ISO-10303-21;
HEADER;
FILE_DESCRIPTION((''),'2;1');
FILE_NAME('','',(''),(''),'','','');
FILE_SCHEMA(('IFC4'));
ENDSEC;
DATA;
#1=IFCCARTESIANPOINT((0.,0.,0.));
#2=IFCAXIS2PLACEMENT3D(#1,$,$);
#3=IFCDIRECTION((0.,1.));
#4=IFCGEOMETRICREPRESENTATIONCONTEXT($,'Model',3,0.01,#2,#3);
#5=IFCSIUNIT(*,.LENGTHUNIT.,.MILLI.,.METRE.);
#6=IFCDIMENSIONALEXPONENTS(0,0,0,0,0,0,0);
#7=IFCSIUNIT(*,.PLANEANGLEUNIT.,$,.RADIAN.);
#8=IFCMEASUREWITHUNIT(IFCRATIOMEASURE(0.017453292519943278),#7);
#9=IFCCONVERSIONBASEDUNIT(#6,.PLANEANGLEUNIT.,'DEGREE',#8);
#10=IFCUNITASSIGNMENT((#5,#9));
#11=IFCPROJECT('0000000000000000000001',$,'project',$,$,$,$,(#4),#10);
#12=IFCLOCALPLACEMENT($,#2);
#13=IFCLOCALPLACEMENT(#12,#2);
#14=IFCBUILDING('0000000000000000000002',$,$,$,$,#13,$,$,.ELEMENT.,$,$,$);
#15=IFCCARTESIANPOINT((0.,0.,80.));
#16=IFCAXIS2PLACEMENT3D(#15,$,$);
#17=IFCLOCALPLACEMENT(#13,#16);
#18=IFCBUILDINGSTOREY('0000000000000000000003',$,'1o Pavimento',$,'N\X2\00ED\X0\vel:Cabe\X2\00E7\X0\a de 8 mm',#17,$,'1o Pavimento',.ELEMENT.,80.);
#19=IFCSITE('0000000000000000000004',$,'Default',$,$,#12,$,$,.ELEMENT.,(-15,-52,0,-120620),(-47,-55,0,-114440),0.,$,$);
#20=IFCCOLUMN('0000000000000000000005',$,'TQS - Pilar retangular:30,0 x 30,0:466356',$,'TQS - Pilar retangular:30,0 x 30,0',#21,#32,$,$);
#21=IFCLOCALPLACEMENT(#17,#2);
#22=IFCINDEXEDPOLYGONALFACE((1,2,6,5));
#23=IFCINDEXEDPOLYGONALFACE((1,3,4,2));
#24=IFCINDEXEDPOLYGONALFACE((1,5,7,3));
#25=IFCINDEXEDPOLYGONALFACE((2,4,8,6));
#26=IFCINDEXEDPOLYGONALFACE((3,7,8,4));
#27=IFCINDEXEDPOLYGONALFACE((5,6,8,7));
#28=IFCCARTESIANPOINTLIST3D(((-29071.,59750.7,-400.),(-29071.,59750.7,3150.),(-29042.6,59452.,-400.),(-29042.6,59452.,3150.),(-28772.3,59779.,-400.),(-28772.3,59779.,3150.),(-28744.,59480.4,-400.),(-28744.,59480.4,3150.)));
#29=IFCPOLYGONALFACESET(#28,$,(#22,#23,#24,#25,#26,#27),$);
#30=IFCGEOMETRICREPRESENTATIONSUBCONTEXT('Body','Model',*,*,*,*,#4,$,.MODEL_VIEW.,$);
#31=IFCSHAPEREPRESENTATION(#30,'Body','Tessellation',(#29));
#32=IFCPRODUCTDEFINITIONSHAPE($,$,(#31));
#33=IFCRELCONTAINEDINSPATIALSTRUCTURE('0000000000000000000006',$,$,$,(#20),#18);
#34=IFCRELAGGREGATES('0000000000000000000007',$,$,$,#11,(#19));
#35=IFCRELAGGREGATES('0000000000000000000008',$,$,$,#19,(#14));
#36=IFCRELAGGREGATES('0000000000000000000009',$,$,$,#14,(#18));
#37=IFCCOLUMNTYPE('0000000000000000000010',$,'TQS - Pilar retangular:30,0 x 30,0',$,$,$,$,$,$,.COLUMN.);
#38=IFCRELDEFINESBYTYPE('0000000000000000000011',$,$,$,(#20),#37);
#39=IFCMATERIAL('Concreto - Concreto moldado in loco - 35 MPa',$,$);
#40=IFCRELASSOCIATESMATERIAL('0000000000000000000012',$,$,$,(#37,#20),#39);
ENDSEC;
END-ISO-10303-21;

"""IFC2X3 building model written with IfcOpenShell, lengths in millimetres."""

from ifc_helpers import new_model, entity, si_unit, converted_unit, direction, frame, origin, origin_2d_with_axis, place, context, subcontext, project, spatial, rectangle, extrude, source, transform, mapped, material, type_object, type_shapes, element, save


model = new_model("IFC2X3")

# Units and contexts
model_context = context("Model", 3, precision=0.01, world=origin(), true_north=direction((0.0, 1.0)))
body_context = subcontext(model_context, "Body", "Model", "MODEL_VIEW")
ifc_project = project(units=[si_unit("LENGTHUNIT", "METRE", prefix="MILLI"), converted_unit("PLANEANGLEUNIT", "DEGREE", entity("IfcRatioMeasure", 0.017453292519943278), si_unit("PLANEANGLEUNIT", "RADIAN"), dimensions=[0, 0, 0, 0, 0, 0, 0])], contexts=[model_context])

# Site, building, storey
site_placement = place(None, origin())
site = spatial("IfcSite", under=ifc_project, at=site_placement, Name="Default", CompositionType="ELEMENT", RefLatitude=(-15, -52, 0, -120620), RefLongitude=(-47, -55, 0, -114440), RefElevation=0.0)
building_placement = place(site_placement, origin())
building = spatial("IfcBuilding", under=site, at=building_placement, CompositionType="ELEMENT")
storey_placement = place(building_placement, frame((0.0, 0.0, 80.0)))
storey = spatial("IfcBuildingStorey", under=building, at=storey_placement, Name="1o Pavimento", ObjectType="Nível:Cabeça de 8 mm", LongName="1o Pavimento", CompositionType="ELEMENT", Elevation=80.0)

# Column
ifc_material = material(Name="Concreto - Concreto moldado in loco - 35 MPa")
column_type_1 = type_object("IfcColumnType", Name="TQS - Pilar retangular:30,0 x 30,0", PredefinedType="COLUMN", material=ifc_material)
shared_shape_1 = source(origin(), body_context, "Body", "SweptSolid", [
    extrude(rectangle(XDim=300.0, YDim=300.0, at=origin_2d_with_axis()), frame((-28907.5, 59615.5, -320.0), z_axis=(0.0, 0.0, 1.0), x_axis=(-0.995529, -0.094456, 0.0)), (0.0, 0.0, 1.0), 3550.0),
])
type_shapes(column_type_1, [shared_shape_1])
column_1_placement = place(storey_placement, frame((0.0, 0.0, -80.0)))
element("IfcColumn", 1, at=column_1_placement, inside=storey, type_object=column_type_1, material=ifc_material, Name="TQS - Pilar retangular:30,0 x 30,0:466356", ObjectType="TQS - Pilar retangular:30,0 x 30,0", context=body_context, shape_type="MappedRepresentation", body=[
    mapped(shared_shape_1, transform((0.0, 0.0, 0.0), scale=1.0)),
])

save(model, "model.ifc")
